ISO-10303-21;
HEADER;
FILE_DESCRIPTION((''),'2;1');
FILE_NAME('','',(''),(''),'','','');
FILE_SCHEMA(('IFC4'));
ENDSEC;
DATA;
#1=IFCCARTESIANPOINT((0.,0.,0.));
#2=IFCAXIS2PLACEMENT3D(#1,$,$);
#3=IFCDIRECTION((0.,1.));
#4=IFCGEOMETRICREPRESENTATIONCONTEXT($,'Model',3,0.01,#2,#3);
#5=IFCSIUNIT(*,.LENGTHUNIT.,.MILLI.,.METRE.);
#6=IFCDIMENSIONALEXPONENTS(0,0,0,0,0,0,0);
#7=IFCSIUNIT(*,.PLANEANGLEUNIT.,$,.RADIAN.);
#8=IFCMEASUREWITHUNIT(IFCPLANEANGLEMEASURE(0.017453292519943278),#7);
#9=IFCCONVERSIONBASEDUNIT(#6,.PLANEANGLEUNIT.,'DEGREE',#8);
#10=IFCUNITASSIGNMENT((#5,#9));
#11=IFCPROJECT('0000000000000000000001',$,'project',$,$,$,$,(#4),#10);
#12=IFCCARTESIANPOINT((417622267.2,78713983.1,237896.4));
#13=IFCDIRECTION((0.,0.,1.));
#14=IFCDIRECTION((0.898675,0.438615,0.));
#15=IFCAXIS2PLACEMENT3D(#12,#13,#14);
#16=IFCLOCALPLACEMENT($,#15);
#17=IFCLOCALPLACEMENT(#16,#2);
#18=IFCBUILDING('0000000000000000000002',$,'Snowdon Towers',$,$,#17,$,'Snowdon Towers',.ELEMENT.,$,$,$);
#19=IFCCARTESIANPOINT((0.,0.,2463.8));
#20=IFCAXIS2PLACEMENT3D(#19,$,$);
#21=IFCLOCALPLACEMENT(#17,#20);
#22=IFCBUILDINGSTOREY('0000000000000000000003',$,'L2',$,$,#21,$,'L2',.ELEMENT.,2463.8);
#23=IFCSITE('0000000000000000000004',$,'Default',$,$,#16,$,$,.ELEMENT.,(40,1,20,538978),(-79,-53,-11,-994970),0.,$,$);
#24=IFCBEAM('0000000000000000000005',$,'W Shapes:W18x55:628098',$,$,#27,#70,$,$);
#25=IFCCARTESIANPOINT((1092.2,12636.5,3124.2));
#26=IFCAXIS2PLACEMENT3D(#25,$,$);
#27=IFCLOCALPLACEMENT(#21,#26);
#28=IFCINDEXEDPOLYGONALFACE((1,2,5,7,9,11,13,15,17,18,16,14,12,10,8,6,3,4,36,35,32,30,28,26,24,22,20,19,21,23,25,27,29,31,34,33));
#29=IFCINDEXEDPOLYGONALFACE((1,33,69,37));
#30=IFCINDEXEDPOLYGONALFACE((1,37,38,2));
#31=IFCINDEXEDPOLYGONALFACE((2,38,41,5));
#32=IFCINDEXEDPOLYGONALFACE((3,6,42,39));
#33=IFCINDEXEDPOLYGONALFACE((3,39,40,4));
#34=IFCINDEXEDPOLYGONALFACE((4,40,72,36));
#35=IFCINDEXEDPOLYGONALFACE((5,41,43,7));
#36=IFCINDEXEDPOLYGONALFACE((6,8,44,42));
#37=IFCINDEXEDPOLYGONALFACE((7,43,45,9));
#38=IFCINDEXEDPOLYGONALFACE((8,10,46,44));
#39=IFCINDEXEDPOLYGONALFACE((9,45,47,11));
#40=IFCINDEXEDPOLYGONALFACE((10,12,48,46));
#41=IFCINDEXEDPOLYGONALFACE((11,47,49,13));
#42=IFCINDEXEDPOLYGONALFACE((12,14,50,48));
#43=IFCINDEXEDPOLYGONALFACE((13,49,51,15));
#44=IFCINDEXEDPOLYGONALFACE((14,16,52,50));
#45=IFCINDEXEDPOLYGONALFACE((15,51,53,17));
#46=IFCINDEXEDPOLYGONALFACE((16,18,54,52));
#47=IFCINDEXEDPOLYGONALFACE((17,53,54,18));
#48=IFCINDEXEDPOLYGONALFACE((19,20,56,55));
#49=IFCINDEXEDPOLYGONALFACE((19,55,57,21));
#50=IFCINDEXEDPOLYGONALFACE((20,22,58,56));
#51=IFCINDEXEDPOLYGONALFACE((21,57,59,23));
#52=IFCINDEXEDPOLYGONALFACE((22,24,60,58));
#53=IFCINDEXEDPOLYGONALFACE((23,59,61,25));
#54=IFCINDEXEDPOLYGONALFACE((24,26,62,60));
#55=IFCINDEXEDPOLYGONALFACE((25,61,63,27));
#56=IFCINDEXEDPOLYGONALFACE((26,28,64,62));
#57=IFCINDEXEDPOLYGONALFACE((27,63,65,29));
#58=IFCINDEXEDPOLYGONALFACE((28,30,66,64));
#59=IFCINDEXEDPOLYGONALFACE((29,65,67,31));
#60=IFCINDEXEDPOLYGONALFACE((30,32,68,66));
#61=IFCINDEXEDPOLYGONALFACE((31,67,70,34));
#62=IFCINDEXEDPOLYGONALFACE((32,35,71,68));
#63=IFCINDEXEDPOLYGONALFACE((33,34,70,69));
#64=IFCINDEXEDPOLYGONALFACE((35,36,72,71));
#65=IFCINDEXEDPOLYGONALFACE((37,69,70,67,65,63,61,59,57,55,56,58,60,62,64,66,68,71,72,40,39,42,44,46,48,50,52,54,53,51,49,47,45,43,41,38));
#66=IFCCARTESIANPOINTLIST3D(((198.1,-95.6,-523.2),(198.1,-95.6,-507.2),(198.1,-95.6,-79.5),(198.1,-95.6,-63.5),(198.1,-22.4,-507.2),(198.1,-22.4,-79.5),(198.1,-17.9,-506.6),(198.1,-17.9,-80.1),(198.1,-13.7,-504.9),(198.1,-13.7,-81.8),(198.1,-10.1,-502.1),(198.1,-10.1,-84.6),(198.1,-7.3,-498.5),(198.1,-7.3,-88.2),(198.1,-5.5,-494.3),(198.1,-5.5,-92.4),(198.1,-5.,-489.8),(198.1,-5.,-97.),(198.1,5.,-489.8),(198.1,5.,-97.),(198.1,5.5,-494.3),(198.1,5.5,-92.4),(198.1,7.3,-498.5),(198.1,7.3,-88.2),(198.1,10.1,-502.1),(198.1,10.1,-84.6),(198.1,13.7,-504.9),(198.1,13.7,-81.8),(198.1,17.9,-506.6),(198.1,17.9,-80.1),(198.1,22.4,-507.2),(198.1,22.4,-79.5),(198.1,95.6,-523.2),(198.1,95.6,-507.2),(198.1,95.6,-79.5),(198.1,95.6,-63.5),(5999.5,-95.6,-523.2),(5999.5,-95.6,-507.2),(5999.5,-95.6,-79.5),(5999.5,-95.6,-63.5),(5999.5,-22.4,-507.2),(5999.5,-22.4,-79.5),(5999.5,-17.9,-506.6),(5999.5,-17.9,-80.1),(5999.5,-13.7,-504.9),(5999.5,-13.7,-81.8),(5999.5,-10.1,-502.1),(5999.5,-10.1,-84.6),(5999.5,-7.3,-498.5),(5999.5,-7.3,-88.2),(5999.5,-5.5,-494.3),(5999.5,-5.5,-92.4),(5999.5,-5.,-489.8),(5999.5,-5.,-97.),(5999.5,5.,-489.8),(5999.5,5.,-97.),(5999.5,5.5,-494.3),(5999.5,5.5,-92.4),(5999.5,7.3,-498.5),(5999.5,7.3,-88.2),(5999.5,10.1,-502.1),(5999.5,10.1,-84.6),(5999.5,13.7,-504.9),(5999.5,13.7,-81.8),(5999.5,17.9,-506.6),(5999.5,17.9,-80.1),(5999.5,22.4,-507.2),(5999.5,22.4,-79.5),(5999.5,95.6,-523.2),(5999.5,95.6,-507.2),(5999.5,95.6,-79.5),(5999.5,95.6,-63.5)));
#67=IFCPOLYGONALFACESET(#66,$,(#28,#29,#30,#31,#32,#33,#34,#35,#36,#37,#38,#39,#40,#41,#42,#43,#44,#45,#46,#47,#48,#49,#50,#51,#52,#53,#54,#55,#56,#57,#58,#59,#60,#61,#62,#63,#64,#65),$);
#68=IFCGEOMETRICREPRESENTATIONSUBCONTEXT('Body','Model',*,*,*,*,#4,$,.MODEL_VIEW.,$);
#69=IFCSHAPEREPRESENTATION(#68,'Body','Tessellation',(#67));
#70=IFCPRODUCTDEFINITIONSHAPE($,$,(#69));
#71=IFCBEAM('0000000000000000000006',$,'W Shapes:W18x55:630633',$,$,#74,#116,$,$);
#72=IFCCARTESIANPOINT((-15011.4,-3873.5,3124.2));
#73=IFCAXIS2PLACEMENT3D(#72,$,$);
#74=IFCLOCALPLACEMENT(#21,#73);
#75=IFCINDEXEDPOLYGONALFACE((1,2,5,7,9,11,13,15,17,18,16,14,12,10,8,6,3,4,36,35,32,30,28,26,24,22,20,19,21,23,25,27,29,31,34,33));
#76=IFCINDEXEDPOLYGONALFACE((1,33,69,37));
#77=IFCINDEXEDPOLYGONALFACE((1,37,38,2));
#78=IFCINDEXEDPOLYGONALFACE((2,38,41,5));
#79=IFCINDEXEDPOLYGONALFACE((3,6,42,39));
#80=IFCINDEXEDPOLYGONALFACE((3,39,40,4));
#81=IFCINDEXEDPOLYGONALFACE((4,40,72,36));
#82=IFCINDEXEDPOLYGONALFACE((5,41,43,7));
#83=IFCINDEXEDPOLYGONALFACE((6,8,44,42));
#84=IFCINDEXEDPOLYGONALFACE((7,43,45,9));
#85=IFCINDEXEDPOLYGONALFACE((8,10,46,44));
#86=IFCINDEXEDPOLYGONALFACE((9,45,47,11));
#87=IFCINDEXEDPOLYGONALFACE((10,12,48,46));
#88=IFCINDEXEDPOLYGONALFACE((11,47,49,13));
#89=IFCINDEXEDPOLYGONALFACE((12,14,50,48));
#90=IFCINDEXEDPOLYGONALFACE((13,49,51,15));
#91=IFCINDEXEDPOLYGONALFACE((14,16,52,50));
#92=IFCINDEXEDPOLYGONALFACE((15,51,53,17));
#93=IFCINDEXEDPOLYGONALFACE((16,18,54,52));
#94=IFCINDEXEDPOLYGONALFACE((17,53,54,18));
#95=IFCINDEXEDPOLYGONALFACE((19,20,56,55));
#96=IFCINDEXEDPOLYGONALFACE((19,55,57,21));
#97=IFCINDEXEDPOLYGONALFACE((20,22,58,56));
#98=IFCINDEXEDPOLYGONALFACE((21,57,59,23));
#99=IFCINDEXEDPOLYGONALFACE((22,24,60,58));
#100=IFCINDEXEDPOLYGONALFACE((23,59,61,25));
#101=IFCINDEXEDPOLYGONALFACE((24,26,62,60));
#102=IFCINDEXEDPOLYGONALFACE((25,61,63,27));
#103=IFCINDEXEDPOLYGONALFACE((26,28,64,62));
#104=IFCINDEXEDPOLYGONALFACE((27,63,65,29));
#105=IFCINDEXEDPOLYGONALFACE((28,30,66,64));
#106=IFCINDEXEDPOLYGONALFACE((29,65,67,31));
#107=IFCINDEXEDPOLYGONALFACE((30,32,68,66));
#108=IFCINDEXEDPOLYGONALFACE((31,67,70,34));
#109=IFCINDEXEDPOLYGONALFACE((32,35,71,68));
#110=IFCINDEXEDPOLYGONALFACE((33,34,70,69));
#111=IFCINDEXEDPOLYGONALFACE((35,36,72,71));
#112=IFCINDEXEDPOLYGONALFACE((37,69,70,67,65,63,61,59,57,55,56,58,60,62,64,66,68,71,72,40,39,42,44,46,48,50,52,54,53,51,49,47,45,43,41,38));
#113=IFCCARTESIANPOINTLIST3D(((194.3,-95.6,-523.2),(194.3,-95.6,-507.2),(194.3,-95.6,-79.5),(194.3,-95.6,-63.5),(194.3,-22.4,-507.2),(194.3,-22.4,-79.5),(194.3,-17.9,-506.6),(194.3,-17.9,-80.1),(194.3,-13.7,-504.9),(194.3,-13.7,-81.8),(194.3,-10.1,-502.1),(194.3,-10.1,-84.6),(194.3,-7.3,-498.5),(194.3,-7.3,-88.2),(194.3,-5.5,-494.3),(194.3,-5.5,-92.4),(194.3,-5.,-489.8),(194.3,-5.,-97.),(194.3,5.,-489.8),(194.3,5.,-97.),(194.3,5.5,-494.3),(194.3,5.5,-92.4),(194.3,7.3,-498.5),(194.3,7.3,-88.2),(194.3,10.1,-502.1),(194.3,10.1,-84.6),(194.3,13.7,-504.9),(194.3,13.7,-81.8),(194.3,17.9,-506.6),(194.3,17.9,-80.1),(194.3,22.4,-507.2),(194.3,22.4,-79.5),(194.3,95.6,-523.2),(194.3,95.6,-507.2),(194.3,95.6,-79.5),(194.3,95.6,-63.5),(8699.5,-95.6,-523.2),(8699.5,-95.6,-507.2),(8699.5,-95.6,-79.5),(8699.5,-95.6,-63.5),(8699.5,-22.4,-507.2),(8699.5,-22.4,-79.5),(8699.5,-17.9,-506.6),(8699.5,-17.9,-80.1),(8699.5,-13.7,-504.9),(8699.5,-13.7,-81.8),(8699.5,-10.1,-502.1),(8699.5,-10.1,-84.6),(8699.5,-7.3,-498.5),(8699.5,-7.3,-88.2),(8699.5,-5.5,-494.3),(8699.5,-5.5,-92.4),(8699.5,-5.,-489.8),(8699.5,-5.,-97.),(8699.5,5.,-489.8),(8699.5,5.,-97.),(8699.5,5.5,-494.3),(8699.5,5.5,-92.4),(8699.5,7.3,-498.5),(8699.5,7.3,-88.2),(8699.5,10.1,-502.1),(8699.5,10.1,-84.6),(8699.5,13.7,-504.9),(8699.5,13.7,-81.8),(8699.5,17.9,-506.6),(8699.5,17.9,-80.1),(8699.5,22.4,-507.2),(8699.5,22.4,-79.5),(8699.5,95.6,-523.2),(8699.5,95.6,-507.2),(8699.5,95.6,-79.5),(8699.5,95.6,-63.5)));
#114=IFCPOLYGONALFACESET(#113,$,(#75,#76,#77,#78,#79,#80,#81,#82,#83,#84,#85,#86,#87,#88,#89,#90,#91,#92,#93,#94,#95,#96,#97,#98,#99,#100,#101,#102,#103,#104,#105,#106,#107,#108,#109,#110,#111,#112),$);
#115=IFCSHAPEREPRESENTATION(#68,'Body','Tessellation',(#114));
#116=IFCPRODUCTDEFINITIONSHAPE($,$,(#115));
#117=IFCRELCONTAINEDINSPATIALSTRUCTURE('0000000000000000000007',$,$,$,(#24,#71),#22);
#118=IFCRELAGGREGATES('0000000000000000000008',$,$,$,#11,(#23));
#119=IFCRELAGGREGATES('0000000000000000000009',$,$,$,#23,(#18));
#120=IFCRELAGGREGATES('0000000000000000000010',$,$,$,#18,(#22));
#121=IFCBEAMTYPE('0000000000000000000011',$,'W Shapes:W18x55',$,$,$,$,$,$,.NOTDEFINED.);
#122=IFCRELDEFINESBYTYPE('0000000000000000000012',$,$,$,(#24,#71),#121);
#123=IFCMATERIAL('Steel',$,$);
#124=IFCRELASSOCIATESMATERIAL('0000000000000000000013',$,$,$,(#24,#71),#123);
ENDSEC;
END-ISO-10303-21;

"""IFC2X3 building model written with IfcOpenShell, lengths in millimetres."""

from ifc_helpers import new_model, entity, si_unit, converted_unit, direction, frame, frame_2d, origin, place, context, subcontext, project, spatial, i_section, extrude, material, type_object, element, save


model = new_model("IFC2X3")

# Units and contexts
model_context = context("Model", 3, precision=0.01, world=origin(), true_north=direction((0.0, 1.0)))
body_context = subcontext(model_context, "Body", "Model", "MODEL_VIEW")
ifc_project = project(units=[si_unit("LENGTHUNIT", "METRE", prefix="MILLI"), converted_unit("PLANEANGLEUNIT", "DEGREE", entity("IfcPlaneAngleMeasure", 0.017453292519943278), si_unit("PLANEANGLEUNIT", "RADIAN"), dimensions=[0, 0, 0, 0, 0, 0, 0])], contexts=[model_context])

# Site, building, storey
site_placement = place(None, frame((417622267.2, 78713983.1, 237896.4), z_axis=(0.0, 0.0, 1.0), x_axis=(0.898675, 0.438615, 0.0)))
site = spatial("IfcSite", under=ifc_project, at=site_placement, Name="Default", CompositionType="ELEMENT", RefLatitude=(40, 1, 20, 538978), RefLongitude=(-79, -53, -11, -994970), RefElevation=0.0)
building_placement = place(site_placement, origin())
building = spatial("IfcBuilding", under=site, at=building_placement, Name="Snowdon Towers", LongName="Snowdon Towers", CompositionType="ELEMENT")
storey_placement = place(building_placement, frame((0.0, 0.0, 2463.8)))
storey = spatial("IfcBuildingStorey", under=building, at=storey_placement, Name="L2", LongName="L2", CompositionType="ELEMENT", Elevation=2463.8)

# Beams
ifc_material_1 = material(Name="Steel")
beam_type_1 = type_object("IfcBeamType", Name="W Shapes:W18x55", PredefinedType="NOTDEFINED")
beam_1_placement = place(storey_placement, frame((1092.2, 12636.5, 3124.2)))
element("IfcBeam", 1, at=beam_1_placement, inside=storey, type_object=beam_type_1, material=ifc_material_1, Name="W Shapes:W18x55:628098", context=body_context, shape_type="SweptSolid", body=[
    extrude(i_section(OverallWidth=191.3, OverallDepth=459.7, WebThickness=9.9, FlangeThickness=16.0, FilletRadius=17.5, at=frame_2d((0.0, 0.0), x_axis=(0.0, 1.0))), frame((198.1, 0.0, -293.4), z_axis=(1.0, 0.0, 0.0), x_axis=(0.0, 0.0, -1.0)), (0.0, 0.0, 1.0), 5801.4),
])
beam_2_placement = place(storey_placement, frame((-15011.4, -3873.5, 3124.2)))
element("IfcBeam", 2, at=beam_2_placement, inside=storey, type_object=beam_type_1, material=ifc_material_1, Name="W Shapes:W18x55:630633", context=body_context, shape_type="SweptSolid", body=[
    extrude(i_section(OverallWidth=191.3, OverallDepth=459.7, WebThickness=9.9, FlangeThickness=16.0, FilletRadius=17.5, at=frame_2d((0.0, 0.0), x_axis=(0.0, 1.0))), frame((194.3, 0.0, -293.4), z_axis=(1.0, 0.0, 0.0), x_axis=(0.0, 0.0, -1.0)), (0.0, 0.0, 1.0), 8505.2),
])

save(model, "model.ifc")
